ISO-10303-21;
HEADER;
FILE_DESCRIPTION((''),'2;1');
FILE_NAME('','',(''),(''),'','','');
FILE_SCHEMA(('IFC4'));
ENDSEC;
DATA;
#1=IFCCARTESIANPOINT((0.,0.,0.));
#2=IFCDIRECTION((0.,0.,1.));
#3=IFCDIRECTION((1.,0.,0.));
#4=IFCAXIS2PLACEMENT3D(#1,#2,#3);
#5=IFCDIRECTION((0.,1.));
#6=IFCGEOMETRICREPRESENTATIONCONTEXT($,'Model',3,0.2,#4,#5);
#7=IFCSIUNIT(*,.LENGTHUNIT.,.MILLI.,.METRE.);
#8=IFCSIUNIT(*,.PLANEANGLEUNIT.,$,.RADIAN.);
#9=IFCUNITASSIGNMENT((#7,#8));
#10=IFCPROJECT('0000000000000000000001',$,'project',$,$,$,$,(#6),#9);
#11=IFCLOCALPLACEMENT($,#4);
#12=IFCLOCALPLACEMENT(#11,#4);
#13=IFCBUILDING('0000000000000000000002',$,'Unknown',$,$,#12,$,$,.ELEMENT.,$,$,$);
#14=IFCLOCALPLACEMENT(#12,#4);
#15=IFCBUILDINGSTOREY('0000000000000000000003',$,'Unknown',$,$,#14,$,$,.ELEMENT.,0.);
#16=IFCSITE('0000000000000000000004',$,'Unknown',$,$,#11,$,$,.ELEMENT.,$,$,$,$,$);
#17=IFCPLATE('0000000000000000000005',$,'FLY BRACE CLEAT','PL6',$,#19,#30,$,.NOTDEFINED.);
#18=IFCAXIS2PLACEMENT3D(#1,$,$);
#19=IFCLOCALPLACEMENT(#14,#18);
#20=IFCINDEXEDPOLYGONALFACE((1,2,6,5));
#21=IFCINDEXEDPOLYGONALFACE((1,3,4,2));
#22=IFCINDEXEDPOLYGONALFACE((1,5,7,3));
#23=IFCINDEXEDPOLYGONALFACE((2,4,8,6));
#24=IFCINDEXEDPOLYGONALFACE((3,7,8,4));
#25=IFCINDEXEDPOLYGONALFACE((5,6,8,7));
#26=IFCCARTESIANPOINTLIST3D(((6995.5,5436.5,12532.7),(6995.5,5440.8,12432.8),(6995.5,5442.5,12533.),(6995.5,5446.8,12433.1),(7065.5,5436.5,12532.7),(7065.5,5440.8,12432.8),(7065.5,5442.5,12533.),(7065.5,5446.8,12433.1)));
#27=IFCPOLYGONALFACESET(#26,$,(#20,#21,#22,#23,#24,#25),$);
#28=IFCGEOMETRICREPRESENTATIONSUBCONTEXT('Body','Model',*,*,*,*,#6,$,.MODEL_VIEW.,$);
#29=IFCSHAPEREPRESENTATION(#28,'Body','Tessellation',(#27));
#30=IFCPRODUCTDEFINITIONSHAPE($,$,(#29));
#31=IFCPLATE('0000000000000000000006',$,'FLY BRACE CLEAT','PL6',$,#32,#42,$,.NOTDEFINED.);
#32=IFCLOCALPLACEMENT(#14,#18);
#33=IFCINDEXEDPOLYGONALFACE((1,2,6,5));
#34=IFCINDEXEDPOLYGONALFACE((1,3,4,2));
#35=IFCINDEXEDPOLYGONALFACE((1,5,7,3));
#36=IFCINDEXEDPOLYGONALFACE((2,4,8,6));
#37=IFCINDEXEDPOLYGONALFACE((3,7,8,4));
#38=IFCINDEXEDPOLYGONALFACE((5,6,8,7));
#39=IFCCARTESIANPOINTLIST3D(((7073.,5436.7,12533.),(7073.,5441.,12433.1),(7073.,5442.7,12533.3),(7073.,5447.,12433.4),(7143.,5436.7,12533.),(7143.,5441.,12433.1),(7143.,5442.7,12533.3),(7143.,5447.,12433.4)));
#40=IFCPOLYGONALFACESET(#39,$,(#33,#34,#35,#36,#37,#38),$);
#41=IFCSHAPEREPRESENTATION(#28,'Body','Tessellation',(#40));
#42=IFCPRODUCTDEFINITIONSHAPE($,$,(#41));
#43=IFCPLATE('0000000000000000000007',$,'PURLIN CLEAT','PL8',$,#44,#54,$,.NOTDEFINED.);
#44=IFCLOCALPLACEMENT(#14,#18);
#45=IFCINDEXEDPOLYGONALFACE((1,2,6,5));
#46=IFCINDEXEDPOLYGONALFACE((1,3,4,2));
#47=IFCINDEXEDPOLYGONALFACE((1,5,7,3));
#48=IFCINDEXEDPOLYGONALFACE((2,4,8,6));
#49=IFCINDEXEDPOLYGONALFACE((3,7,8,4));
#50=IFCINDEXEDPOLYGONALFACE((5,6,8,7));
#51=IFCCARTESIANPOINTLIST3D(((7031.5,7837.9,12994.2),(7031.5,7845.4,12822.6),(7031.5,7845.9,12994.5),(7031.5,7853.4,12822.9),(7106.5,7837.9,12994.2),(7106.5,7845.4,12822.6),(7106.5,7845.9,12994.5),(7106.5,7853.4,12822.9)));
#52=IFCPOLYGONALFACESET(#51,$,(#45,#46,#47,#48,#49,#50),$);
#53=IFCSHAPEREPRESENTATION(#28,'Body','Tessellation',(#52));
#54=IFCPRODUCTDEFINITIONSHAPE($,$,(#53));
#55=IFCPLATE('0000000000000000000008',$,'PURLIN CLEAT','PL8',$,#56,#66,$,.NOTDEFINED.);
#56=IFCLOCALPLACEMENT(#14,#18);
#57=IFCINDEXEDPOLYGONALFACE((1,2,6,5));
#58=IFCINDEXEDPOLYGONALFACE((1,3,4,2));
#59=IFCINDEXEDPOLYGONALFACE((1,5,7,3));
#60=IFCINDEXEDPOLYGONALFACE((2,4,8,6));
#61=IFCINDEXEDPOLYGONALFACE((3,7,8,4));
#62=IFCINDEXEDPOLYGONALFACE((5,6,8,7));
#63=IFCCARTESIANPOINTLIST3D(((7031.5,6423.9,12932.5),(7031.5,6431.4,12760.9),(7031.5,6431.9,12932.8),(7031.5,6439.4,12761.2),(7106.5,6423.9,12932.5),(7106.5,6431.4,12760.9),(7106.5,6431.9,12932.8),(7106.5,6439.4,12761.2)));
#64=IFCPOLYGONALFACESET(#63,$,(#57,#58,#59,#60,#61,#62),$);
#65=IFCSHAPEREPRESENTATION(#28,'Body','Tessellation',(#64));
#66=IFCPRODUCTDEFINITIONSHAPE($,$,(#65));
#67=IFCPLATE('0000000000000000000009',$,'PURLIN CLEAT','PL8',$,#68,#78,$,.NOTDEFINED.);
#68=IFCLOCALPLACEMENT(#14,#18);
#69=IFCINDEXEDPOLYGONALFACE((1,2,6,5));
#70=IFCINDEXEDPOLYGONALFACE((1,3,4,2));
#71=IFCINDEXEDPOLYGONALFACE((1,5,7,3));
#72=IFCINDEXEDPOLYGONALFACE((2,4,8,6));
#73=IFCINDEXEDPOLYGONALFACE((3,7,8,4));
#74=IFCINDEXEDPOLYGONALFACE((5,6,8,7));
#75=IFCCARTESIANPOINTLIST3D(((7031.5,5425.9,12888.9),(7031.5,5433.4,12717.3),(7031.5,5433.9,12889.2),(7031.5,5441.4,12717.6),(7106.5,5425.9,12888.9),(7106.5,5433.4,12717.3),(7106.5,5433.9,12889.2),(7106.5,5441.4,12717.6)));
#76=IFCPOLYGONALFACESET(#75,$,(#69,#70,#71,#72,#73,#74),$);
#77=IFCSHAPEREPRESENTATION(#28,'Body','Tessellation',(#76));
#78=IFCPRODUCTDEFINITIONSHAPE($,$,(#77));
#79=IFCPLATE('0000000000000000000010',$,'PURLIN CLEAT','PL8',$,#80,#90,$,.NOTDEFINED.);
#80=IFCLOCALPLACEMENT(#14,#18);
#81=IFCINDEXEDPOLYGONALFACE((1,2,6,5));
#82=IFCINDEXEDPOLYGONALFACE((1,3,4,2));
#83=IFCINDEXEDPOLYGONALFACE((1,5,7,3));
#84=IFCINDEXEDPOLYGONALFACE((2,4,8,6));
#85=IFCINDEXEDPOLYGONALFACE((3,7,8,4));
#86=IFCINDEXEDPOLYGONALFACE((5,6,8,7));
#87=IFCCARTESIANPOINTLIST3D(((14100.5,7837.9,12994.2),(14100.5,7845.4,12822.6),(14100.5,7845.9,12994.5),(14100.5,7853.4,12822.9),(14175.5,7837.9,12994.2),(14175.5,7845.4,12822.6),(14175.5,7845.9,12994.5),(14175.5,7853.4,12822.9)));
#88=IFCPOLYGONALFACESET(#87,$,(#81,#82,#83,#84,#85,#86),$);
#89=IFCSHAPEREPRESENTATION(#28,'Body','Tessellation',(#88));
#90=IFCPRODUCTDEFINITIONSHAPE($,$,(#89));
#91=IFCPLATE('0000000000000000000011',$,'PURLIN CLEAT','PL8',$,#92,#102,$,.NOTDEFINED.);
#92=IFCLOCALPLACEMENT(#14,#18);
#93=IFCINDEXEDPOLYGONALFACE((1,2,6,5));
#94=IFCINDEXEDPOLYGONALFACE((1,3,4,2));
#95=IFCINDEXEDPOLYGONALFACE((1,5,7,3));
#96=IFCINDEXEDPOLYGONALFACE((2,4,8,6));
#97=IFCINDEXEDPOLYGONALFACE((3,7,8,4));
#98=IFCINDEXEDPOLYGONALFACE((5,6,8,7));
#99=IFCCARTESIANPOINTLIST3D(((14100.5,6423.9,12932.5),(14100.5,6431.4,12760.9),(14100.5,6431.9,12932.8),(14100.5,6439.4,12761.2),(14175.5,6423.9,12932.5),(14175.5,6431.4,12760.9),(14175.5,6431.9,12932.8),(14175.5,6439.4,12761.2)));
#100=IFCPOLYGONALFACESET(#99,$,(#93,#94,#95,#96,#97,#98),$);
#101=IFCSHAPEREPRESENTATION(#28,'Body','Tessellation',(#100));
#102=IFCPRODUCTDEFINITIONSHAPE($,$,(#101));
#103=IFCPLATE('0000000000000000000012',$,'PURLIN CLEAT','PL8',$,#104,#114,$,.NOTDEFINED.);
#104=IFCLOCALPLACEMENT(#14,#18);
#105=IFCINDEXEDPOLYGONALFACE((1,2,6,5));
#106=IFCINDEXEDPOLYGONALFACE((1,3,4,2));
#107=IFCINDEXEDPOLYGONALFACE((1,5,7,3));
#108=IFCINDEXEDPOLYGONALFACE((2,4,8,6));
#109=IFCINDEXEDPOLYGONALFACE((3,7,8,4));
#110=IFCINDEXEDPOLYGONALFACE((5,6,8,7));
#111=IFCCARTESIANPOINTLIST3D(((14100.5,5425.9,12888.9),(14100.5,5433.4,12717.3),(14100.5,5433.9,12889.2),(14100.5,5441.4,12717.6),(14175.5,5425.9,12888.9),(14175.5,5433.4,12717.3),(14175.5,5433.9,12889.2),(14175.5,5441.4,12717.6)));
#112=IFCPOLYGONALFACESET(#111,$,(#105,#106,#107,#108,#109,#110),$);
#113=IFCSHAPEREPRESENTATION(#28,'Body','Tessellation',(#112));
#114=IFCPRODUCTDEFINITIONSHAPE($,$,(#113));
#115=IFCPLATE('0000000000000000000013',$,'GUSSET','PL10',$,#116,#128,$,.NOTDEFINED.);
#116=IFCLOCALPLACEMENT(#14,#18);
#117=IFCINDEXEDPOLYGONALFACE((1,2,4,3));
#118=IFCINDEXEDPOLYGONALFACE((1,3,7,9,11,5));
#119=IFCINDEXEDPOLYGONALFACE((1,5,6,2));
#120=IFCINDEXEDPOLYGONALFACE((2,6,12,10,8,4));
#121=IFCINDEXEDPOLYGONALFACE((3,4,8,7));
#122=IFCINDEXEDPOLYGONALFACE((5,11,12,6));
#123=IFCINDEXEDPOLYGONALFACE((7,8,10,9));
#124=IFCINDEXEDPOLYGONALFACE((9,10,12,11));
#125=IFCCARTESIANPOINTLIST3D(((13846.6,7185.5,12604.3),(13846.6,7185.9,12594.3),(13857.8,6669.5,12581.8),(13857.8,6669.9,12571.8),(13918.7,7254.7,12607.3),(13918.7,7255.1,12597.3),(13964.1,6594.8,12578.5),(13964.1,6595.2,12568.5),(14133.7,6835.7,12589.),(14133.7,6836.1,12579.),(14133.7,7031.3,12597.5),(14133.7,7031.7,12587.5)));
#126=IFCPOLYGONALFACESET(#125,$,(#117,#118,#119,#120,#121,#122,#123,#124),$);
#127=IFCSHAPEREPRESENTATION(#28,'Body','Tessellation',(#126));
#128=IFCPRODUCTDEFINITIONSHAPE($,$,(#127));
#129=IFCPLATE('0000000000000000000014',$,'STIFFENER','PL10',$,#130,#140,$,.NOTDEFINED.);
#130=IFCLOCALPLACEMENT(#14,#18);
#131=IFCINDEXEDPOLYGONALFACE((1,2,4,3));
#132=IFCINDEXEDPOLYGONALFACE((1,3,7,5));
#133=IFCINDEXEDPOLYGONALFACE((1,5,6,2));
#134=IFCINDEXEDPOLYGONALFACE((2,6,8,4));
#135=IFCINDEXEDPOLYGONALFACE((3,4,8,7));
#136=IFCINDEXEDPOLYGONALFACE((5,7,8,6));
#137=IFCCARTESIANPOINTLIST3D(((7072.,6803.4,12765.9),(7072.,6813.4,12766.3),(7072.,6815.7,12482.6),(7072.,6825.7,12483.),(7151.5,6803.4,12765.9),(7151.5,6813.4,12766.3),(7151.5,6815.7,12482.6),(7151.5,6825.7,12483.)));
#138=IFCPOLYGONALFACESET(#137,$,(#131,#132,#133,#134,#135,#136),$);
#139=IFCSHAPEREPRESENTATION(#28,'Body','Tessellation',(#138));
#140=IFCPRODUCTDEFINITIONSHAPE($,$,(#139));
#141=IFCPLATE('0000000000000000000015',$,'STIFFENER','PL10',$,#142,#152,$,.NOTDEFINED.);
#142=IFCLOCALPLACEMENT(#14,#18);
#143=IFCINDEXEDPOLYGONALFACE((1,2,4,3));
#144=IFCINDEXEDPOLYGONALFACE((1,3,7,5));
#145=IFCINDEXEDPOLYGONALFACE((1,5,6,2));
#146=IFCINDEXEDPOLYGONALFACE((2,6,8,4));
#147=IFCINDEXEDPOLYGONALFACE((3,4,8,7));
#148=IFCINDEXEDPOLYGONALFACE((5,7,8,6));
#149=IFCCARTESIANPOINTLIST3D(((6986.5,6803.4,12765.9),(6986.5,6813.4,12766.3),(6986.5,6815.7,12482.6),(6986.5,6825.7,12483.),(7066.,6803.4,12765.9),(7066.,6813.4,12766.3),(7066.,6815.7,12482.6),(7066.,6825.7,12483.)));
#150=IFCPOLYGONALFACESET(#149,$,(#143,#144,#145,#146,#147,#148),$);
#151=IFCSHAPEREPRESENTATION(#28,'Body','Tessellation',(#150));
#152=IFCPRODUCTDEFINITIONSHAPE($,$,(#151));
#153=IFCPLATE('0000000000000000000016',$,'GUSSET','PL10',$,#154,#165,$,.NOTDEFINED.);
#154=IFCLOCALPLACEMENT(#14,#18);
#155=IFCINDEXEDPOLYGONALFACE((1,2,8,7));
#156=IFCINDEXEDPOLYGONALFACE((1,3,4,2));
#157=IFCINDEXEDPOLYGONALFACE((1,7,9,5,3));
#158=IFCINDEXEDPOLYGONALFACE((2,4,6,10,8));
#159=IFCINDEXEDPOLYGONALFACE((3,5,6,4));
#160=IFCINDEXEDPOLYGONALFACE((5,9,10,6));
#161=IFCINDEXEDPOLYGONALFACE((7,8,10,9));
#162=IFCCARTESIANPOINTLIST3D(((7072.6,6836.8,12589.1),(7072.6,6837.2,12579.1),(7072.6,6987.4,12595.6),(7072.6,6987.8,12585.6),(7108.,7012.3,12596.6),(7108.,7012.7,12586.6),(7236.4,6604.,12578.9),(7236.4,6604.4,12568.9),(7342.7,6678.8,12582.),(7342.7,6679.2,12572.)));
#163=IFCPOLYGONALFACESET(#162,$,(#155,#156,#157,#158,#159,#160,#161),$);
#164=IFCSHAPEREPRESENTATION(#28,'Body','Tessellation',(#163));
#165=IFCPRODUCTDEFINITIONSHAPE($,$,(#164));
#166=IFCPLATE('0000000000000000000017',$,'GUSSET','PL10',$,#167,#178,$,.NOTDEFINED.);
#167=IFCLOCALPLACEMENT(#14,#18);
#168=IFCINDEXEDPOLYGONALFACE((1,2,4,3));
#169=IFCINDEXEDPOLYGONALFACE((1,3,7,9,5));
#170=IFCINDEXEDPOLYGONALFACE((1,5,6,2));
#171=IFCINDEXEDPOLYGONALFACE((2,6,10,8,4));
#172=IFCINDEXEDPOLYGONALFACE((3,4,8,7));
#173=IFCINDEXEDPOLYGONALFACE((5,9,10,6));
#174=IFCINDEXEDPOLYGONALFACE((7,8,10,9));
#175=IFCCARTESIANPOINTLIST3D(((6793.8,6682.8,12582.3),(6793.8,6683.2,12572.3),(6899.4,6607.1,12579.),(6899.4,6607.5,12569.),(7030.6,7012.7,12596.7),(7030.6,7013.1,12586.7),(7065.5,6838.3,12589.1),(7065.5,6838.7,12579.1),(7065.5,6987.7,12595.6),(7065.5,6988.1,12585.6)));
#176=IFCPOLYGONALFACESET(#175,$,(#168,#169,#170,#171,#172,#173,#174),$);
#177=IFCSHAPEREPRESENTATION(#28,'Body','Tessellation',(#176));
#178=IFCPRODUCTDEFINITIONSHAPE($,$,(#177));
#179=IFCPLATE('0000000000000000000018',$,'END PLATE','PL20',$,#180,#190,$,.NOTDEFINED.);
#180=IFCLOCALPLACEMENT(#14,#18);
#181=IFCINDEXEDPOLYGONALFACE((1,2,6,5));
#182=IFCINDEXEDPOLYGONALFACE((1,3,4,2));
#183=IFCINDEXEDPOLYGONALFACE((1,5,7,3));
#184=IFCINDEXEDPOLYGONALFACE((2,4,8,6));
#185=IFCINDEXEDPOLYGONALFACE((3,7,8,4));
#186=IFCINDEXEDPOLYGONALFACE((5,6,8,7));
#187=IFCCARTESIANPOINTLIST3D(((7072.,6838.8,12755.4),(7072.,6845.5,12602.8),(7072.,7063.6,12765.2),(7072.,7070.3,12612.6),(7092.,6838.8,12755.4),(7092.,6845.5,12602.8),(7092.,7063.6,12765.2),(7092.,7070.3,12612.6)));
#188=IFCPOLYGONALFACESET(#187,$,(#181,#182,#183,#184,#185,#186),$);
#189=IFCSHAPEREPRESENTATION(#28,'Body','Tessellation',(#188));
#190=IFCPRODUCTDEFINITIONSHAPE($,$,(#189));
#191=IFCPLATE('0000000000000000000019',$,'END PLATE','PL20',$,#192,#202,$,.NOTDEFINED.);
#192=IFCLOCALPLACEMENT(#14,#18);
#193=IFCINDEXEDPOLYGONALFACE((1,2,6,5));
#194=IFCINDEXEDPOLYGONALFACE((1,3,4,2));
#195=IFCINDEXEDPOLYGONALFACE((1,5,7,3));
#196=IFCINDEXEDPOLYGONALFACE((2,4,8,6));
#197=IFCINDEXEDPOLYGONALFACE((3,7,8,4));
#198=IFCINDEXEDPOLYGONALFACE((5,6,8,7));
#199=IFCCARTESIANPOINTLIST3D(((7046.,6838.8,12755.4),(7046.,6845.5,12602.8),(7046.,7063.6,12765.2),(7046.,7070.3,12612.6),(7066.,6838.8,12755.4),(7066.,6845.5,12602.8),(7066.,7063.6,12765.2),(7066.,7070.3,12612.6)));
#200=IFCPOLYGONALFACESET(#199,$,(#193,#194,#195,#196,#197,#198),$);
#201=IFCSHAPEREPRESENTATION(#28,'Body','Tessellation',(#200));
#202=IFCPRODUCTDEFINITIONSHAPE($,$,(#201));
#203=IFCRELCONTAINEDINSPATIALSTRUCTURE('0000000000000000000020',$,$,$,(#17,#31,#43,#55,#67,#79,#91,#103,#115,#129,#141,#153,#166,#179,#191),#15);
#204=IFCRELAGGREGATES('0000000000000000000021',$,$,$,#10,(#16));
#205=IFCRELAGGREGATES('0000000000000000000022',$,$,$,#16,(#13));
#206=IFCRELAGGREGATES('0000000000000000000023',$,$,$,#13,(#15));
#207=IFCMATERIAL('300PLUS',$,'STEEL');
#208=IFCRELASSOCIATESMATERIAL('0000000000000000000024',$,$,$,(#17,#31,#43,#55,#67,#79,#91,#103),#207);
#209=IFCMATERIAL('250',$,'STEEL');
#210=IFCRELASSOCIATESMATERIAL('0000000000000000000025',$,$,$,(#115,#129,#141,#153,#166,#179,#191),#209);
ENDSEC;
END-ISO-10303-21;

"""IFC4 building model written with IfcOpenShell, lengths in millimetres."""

from ifc_helpers import new_model, si_unit, direction, frame, origin_with_axes, place, context, subcontext, project, spatial, line, indexed_curve, outline, extrude, material, element, save


model = new_model("IFC4")

# Units and contexts
model_context = context("Model", 3, precision=0.2, world=origin_with_axes(), true_north=direction((0.0, 1.0)))
body_context = subcontext(model_context, "Body", "Model", "MODEL_VIEW")
ifc_project = project(units=[si_unit("LENGTHUNIT", "METRE", prefix="MILLI"), si_unit("PLANEANGLEUNIT", "RADIAN")], contexts=[model_context])

# Site, building, storey
site_placement = place(None, origin_with_axes())
site = spatial("IfcSite", under=ifc_project, at=site_placement, Name="Unknown", CompositionType="ELEMENT")
building_placement = place(site_placement, origin_with_axes())
building = spatial("IfcBuilding", under=site, at=building_placement, Name="Unknown", CompositionType="ELEMENT")
storey_placement = place(building_placement, origin_with_axes())
storey = spatial("IfcBuildingStorey", under=building, at=storey_placement, Name="Unknown", CompositionType="ELEMENT", Elevation=0.0)

# Shared definitions
ifc_material_1 = material(Name="300PLUS", Category="STEEL")

# Plates
for number, where, z_axis, x_axis, name in (
    (1, (7065.5, 5443.8, 12432.9), (0.0, 0.999075, 0.043003), (-1.0, 0.0, 0.0), "FLY BRACE CLEAT"),
    (2, (7073.0, 5439.7, 12533.1), (0.0, 0.999075, 0.043003), (1.0, 0.0, 0.0), "FLY BRACE CLEAT"),
):
    element("IfcPlate", number, at=place(storey_placement, frame(where, z_axis=z_axis, x_axis=x_axis)), inside=storey, material=ifc_material_1, Name=name, Description="PL6", PredefinedType="NOTDEFINED", context=body_context, shape_type="SolidModel", body=[
        extrude(outline(indexed_curve([(0.0, 0.0), (70.0, 0.0), (70.0, 100.0), (0.0, 100.0)], segments=[line(1, 2, 3, 4, 1)])), frame((0.0, 0.0, 3.0), z_axis=(0.0, 0.0, 1.0), x_axis=(1.0, 0.0, 0.0)), (0.0, 0.0, -1.0), 6.0),
    ])
for number, where, z_axis, x_axis, name in (
    (3, (7031.5, 7841.9, 12994.4), (0.0, 0.999046, 0.043665), (1.0, 0.0, 0.0), "PURLIN CLEAT"),
    (4, (7031.5, 6427.9, 12932.7), (0.0, 0.999046, 0.043665), (1.0, 0.0, 0.0), "PURLIN CLEAT"),
    (5, (7031.5, 5429.9, 12889.1), (0.0, 0.999046, 0.043665), (1.0, 0.0, 0.0), "PURLIN CLEAT"),
    (6, (14100.5, 7841.9, 12994.4), (0.0, 0.999046, 0.043665), (1.0, 0.0, 0.0), "PURLIN CLEAT"),
    (7, (14100.5, 6427.9, 12932.7), (0.0, 0.999046, 0.043665), (1.0, 0.0, 0.0), "PURLIN CLEAT"),
    (8, (14100.5, 5429.9, 12889.1), (0.0, 0.999046, 0.043665), (1.0, 0.0, 0.0), "PURLIN CLEAT"),
):
    element("IfcPlate", number, at=place(storey_placement, frame(where, z_axis=z_axis, x_axis=x_axis)), inside=storey, material=ifc_material_1, Name=name, Description="PL8", PredefinedType="NOTDEFINED", context=body_context, shape_type="SolidModel", body=[
        extrude(outline(indexed_curve([(0.0, 0.0), (75.0, 0.0), (75.0, 171.8), (0.0, 171.8)], segments=[line(1, 2, 3, 4, 1)])), frame((0.0, 0.0, 4.0), z_axis=(0.0, 0.0, 1.0), x_axis=(1.0, 0.0, 0.0)), (0.0, 0.0, -1.0), 8.0),
    ])
ifc_material_2 = material(Name="250", Category="STEEL")
plate_1_placement = place(storey_placement, frame((13846.6, 7185.7, 12599.3), z_axis=(0.000237, -0.043558, 0.999051), x_axis=(0.02168, -0.998816, -0.043553)))
element("IfcPlate", 9, at=plate_1_placement, inside=storey, material=ifc_material_2, Name="GUSSET", Description="PL10", PredefinedType="NOTDEFINED", context=body_context, shape_type="SolidModel", body=[
    extrude(outline(indexed_curve([(0.0, 0.0), (516.6, 0.0), (593.7, 104.7), (356.3, 279.4), (160.5, 283.7), (-67.7, 73.6)], segments=[line(1, 2, 3, 4, 5, 6, 1)])), frame((0.0, 0.0, 5.0), z_axis=(0.0, 0.0, 1.0), x_axis=(1.0, 0.0, 0.0)), (0.0, 0.0, -1.0), 10.0),
])
for number, where, z_axis, x_axis, name in (
    (10, (7151.5, 6820.7, 12482.8), (0.0, 0.999059, 0.043376), (-1.0, 0.0, 0.0), "STIFFENER"),
    (11, (7066.0, 6820.7, 12482.8), (0.0, 0.999059, 0.043376), (-1.0, 0.0, 0.0), "STIFFENER"),
):
    element("IfcPlate", number, at=place(storey_placement, frame(where, z_axis=z_axis, x_axis=x_axis)), inside=storey, material=ifc_material_2, Name=name, Description="PL10", PredefinedType="NOTDEFINED", context=body_context, shape_type="SolidModel", body=[
        extrude(outline(indexed_curve([(0.0, 0.0), (79.5, 0.0), (79.5, 283.6), (0.0, 283.6)], segments=[line(1, 2, 3, 4, 1)])), frame((0.0, 0.0, 5.0), z_axis=(0.0, 0.0, 1.0), x_axis=(1.0, 0.0, 0.0)), (0.0, 0.0, -1.0), 10.0),
    ])
plate_2_placement = place(storey_placement, frame((7072.6, 6837.0, 12584.1), z_axis=(0.000928, -0.043121, 0.999069), x_axis=(0.575072, -0.817319, -0.03581)))
element("IfcPlate", 12, at=plate_2_placement, inside=storey, material=ifc_material_2, Name="GUSSET", Description="PL10", PredefinedType="NOTDEFINED", context=body_context, shape_type="SolidModel", body=[
    extrude(outline(indexed_curve([(0.0, 0.0), (284.8, 0.0), (284.7, 130.0), (-123.4, 130.0), (-123.3, 86.7)], segments=[line(1, 2, 3, 4, 5, 1)])), frame((0.0, 0.0, 5.0), z_axis=(0.0, 0.0, 1.0), x_axis=(1.0, 0.0, 0.0)), (0.0, 0.0, -1.0), 10.0),
])
plate_3_placement = place(storey_placement, frame((7030.6, 7012.9, 12591.7), z_axis=(0.000166, -0.043727, 0.999044), x_axis=(-0.582757, -0.811873, -0.035438)))
element("IfcPlate", 13, at=plate_3_placement, inside=storey, material=ifc_material_2, Name="GUSSET", Description="PL10", PredefinedType="NOTDEFINED", context=body_context, shape_type="SolidModel", body=[
    extrude(outline(indexed_curve([(0.0, 0.0), (406.3, 0.0), (406.4, 130.0), (121.5, 130.1), (0.0, 42.9)], segments=[line(1, 2, 3, 4, 5, 1)])), frame((0.0, 0.0, 5.0), z_axis=(0.0, 0.0, 1.0), x_axis=(1.0, 0.0, 0.0)), (0.0, 0.0, -1.0), 10.0),
])
plate_4_placement = place(storey_placement, frame((7082.0, 7063.6, 12765.2), z_axis=(1.0, 0.0, 0.0), x_axis=(0.0, -0.999051, -0.043553)))
element("IfcPlate", 14, at=plate_4_placement, inside=storey, material=ifc_material_2, Name="END PLATE", Description="PL20", PredefinedType="NOTDEFINED", context=body_context, shape_type="SolidModel", body=[
    extrude(outline(indexed_curve([(0.0, 0.0), (225.0, 0.0), (225.0, 152.7), (0.0, 152.7)], segments=[line(1, 2, 3, 4, 1)])), frame((0.0, 0.0, 10.0), z_axis=(0.0, 0.0, 1.0), x_axis=(1.0, 0.0, 0.0)), (0.0, 0.0, -1.0), 20.0),
])
plate_5_placement = place(storey_placement, frame((7056.0, 7070.3, 12612.6), z_axis=(-1.0, 0.0, 0.0), x_axis=(0.0, -0.999051, -0.043553)))
element("IfcPlate", 15, at=plate_5_placement, inside=storey, material=ifc_material_2, Name="END PLATE", Description="PL20", PredefinedType="NOTDEFINED", context=body_context, shape_type="SolidModel", body=[
    extrude(outline(indexed_curve([(0.0, 0.0), (225.0, 0.0), (225.1, 152.7), (0.0, 152.7)], segments=[line(1, 2, 3, 4, 1)])), frame((0.0, 0.0, 10.0), z_axis=(0.0, 0.0, 1.0), x_axis=(1.0, 0.0, 0.0)), (0.0, 0.0, -1.0), 20.0),
])

save(model, "model.ifc")
